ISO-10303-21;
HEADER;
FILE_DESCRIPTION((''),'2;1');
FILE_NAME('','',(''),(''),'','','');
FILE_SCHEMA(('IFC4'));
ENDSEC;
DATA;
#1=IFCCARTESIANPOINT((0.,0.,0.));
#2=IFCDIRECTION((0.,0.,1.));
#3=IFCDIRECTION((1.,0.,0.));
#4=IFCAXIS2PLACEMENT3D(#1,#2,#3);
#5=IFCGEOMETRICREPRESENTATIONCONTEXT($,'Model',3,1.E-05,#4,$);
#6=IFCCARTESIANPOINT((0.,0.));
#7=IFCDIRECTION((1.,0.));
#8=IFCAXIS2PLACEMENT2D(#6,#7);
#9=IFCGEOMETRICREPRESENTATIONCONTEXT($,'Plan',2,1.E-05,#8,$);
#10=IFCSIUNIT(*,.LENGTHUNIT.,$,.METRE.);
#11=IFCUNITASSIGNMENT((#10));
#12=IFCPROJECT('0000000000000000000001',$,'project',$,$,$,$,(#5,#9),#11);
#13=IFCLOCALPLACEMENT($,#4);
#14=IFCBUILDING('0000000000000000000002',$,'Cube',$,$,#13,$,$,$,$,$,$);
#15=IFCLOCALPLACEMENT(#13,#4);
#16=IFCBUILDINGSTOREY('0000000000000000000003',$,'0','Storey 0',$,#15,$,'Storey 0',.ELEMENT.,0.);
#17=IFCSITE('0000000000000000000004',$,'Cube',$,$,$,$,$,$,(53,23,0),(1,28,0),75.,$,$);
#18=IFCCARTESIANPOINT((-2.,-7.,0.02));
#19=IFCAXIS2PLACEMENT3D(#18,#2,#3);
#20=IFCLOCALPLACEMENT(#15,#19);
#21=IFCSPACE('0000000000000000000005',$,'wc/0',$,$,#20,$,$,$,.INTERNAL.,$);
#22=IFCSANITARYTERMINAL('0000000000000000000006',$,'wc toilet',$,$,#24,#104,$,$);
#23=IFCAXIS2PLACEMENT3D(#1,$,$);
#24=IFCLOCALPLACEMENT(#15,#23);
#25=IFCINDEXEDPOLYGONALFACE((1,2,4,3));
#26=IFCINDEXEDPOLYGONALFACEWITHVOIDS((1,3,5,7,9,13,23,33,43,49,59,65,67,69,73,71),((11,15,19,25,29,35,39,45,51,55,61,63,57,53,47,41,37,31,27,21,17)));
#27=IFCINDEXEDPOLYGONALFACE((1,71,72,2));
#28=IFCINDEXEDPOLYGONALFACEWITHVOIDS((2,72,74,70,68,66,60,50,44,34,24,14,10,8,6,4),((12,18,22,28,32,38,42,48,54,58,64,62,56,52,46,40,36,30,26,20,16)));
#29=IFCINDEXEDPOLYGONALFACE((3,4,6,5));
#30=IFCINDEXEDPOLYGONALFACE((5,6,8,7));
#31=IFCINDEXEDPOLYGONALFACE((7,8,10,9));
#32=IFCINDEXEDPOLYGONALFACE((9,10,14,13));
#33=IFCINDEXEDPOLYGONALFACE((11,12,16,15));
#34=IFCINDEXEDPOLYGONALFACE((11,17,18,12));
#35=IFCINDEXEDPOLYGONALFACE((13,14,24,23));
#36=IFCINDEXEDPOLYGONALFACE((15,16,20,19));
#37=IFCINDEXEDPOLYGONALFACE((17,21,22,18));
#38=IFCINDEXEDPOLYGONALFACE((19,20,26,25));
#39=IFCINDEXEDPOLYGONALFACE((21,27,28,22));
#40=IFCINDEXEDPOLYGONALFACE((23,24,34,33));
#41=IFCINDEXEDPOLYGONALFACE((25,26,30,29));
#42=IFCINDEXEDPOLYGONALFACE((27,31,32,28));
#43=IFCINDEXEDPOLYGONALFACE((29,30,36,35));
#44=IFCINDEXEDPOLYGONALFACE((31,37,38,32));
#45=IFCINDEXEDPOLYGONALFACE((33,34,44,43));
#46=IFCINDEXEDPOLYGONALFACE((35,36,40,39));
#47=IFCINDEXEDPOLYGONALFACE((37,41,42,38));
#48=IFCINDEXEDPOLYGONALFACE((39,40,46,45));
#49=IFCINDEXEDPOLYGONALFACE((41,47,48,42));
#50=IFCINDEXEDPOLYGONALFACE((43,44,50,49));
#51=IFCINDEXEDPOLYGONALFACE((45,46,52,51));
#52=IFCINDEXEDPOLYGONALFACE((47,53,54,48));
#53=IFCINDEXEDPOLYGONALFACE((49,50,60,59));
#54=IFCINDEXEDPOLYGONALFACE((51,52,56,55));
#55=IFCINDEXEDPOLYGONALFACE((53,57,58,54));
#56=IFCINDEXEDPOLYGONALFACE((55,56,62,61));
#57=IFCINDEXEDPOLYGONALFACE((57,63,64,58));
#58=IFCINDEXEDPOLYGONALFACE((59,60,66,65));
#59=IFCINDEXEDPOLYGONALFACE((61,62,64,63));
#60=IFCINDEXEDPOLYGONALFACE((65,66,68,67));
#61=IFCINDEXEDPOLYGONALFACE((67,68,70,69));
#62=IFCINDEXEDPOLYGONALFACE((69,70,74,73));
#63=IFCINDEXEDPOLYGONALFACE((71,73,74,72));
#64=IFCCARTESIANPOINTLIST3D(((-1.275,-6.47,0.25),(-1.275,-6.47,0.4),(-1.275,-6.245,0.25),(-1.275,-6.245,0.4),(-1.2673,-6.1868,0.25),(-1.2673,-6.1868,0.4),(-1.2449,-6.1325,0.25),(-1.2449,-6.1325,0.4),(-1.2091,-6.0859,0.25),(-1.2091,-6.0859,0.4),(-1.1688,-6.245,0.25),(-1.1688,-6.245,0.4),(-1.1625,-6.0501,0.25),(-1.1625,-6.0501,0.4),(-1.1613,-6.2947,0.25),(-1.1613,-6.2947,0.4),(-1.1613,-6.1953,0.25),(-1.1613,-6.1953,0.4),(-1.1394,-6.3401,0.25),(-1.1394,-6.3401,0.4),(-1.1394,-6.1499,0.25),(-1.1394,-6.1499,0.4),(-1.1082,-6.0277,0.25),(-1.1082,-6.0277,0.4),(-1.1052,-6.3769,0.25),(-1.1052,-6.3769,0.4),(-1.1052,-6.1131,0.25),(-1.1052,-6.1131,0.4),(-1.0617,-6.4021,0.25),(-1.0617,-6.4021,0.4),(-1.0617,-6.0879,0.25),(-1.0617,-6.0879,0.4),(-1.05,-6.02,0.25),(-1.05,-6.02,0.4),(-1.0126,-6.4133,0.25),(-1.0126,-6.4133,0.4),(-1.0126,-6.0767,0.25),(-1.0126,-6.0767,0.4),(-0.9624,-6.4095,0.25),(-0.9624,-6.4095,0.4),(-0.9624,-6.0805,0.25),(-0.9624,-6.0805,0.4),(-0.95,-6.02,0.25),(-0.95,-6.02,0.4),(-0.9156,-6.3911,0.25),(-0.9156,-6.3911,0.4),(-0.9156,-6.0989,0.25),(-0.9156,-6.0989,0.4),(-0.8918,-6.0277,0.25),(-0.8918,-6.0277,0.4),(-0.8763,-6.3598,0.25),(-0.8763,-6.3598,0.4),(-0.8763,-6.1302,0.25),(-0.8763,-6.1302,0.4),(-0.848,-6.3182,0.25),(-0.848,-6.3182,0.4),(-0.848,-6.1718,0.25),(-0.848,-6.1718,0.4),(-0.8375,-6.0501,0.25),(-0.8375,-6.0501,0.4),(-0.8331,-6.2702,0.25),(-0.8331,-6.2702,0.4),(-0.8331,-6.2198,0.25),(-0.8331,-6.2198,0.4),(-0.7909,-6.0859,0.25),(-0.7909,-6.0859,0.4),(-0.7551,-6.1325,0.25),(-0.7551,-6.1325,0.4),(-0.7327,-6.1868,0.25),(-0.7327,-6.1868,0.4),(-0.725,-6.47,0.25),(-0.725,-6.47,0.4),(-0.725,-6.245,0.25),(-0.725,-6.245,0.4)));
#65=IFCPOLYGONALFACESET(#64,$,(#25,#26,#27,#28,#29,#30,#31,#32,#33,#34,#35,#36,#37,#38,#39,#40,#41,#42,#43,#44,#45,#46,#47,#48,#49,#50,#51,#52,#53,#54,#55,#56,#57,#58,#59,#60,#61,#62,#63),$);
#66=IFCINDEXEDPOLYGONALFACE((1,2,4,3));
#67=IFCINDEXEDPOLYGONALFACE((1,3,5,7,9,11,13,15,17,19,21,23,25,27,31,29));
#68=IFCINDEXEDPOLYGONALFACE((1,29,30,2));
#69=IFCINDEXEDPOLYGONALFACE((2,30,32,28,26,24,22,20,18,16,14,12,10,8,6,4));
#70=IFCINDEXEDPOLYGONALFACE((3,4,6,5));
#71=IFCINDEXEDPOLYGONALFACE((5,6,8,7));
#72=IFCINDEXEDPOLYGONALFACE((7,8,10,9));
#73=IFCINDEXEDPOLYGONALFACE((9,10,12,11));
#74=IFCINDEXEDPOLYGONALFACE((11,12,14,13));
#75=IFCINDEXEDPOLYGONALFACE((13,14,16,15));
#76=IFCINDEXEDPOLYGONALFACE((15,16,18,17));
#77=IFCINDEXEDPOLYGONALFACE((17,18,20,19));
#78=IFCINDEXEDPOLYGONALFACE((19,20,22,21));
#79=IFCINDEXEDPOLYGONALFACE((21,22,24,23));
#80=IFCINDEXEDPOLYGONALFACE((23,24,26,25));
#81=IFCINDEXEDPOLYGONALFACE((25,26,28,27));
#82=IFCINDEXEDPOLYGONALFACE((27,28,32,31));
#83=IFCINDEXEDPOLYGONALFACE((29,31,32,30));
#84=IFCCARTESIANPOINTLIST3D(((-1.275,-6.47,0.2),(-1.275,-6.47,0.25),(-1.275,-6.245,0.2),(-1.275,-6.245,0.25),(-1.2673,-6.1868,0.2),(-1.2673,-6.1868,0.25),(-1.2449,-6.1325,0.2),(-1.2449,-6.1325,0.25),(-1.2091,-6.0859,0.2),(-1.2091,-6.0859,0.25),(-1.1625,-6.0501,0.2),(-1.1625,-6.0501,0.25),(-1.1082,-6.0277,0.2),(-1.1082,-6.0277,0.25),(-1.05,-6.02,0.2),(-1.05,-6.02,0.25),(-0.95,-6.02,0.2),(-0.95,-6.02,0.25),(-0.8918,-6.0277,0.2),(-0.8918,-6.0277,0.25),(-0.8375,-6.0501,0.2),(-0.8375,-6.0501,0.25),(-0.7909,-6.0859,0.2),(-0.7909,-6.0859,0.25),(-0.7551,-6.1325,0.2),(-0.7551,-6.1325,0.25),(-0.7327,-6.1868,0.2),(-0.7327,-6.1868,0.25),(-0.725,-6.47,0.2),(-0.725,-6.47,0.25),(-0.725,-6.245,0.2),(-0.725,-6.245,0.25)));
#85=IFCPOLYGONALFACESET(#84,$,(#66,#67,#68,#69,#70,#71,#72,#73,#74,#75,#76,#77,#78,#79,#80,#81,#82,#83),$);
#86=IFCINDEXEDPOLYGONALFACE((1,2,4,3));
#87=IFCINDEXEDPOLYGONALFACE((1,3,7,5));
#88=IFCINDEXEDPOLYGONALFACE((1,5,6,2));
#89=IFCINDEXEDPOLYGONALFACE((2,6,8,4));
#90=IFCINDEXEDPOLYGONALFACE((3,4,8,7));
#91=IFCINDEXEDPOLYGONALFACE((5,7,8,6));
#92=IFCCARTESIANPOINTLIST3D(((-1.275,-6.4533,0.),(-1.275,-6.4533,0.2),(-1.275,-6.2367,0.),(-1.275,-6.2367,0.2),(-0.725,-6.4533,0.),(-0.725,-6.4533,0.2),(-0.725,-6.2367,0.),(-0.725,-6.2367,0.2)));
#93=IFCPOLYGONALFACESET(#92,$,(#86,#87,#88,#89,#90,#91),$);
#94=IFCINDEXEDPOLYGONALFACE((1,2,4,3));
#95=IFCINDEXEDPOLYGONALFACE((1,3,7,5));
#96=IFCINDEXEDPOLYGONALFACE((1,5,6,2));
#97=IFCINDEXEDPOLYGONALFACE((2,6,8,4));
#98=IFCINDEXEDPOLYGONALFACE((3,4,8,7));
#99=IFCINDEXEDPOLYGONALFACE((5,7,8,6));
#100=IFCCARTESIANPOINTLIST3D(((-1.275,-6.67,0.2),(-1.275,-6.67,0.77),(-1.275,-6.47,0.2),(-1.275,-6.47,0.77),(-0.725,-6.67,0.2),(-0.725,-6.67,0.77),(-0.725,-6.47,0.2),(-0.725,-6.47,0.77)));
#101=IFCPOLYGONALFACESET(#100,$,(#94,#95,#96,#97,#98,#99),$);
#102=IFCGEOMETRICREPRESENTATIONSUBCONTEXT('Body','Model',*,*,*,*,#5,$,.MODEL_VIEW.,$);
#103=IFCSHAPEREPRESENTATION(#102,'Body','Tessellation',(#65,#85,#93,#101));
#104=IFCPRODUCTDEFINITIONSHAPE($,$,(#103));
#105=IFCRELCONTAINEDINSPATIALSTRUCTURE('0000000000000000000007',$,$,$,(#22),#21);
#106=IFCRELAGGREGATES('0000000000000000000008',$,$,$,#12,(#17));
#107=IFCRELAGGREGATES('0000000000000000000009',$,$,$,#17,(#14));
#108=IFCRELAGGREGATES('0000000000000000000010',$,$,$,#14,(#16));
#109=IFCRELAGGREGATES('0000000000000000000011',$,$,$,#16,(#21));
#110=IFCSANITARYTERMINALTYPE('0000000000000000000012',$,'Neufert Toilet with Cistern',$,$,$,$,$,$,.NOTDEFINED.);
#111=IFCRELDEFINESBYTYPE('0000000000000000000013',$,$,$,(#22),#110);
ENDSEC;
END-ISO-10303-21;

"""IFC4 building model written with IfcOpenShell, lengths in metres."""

from ifc_helpers import new_model, entity, si_unit, frame, frame_2d, origin_with_axes, origin_2d_with_axis, place, context, subcontext, project, spatial, line, arc, indexed_curve, circle_curve, outline, extrude, shape, source, transform, mapped, type_object, type_shapes, element, save


model = new_model("IFC4")

# Units and contexts
model_context = context("Model", 3, precision=1e-05, world=origin_with_axes())
plan_context = context("Plan", 2, precision=1e-05, world=origin_2d_with_axis())
body_context_1 = subcontext(model_context, "Body", "Model", "MODEL_VIEW")
body_context_2 = subcontext(plan_context, "Body", "Plan", "PLAN_VIEW")
ifc_project = project(units=[si_unit("LENGTHUNIT", "METRE")], contexts=[model_context, plan_context])

# Site, building, storey
site = spatial("IfcSite", under=ifc_project, Name="Cube", RefLatitude=(53, 23, 0), RefLongitude=(1, 28, 0), RefElevation=75.0)
building_placement = place(None, origin_with_axes())
building = spatial("IfcBuilding", under=site, at=building_placement, Name="Cube")
storey_placement = place(building_placement, origin_with_axes())
storey = spatial("IfcBuildingStorey", under=building, at=storey_placement, Name="0", Description="Storey 0", LongName="Storey 0", CompositionType="ELEMENT", Elevation=0.0)

# Shared definitions
space_1_placement = place(storey_placement, frame((-2.0, -7.0, 0.02), z_axis=(0.0, 0.0, 1.0), x_axis=(1.0, 0.0, 0.0)))
space_1 = spatial("IfcSpace", under=storey, at=space_1_placement, Name="wc/0", PredefinedType="INTERNAL")

# Sanitary terminal
sanitary_terminal_type_1 = type_object("IfcSanitaryTerminalType", Name="Neufert Toilet with Cistern", PredefinedType="NOTDEFINED")
shared_shape_1 = source(origin_with_axes(), body_context_1, "Body", "SweptSolid", [
    extrude(outline(indexed_curve([(-0.275, -0.2), (0.275, -0.2), (0.275, -0.425), (0.2091, -0.5841), (0.05, -0.65), (-0.05, -0.65), (-0.2091, -0.5841), (-0.275, -0.425)], segments=[line(1, 2), line(2, 3), arc(3, 4, 5), line(5, 6), arc(6, 7, 8), line(8, 1)]), holes=[circle_curve(frame_2d((0.0, -0.425)), 0.1688)]), frame((0.0, 0.0, 0.25), z_axis=(0.0, 0.0, 1.0), x_axis=(1.0, 0.0, 0.0)), (0.0, 0.0, 1.0), 0.15),
    extrude(outline(indexed_curve([(-0.275, -0.2), (0.275, -0.2), (0.275, -0.425), (0.2091, -0.5841), (0.05, -0.65), (-0.05, -0.65), (-0.2091, -0.5841), (-0.275, -0.425)], segments=[line(1, 2), line(2, 3), arc(3, 4, 5), line(5, 6), arc(6, 7, 8), line(8, 1)])), frame((0.0, 0.0, 0.2), z_axis=(0.0, 0.0, 1.0), x_axis=(1.0, 0.0, 0.0)), (0.0, 0.0, 1.0), 0.05),
    extrude(outline(indexed_curve([(-0.275, -0.2167), (0.275, -0.2167), (0.275, -0.4333), (-0.275, -0.4333)], segments=[line(1, 2, 3, 4, 1)])), origin_with_axes(), (0.0, 0.0, 1.0), 0.2),
    extrude(outline(indexed_curve([(-0.275, 0.0), (0.275, 0.0), (0.275, -0.2), (-0.275, -0.2)], segments=[line(1, 2, 3, 4, 1)])), frame((0.0, 0.0, 0.2), z_axis=(0.0, 0.0, 1.0), x_axis=(1.0, 0.0, 0.0)), (0.0, 0.0, 1.0), 0.57),
])
shared_shape_2 = source(origin_with_axes(), body_context_2, "Body", "Curve2D", [
    entity("IfcIndexedPolyCurve", entity("IfcCartesianPointList2D", [[-0.275, 0.0], [0.275, 0.0], [0.275, -0.2], [-0.275, -0.2]]), [entity("IfcLineIndex", [1, 2, 3, 4, 1])]),
    entity("IfcIndexedPolyCurve", entity("IfcCartesianPointList2D", [[0.165, -0.2], [0.1925, -0.335]])),
    entity("IfcTrimmedCurve", entity("IfcEllipse", entity("IfcAxis2Placement2D", entity("IfcCartesianPoint", [0.0, -0.335]), entity("IfcDirection", [1.0, 0.0])), 0.1925, 0.315), [entity("IfcCartesianPoint", [-0.1925, -0.335])], [entity("IfcCartesianPoint", [0.1925, -0.335])], True, "CARTESIAN"),
    entity("IfcIndexedPolyCurve", entity("IfcCartesianPointList2D", [[-0.165, -0.2], [-0.1925, -0.335]])),
    entity("IfcEllipse", entity("IfcAxis2Placement2D", entity("IfcCartesianPoint", [0.0, -0.452]), entity("IfcDirection", [1.0, 0.0])), 0.1313, 0.1575),
    entity("IfcIndexedPolyCurve", entity("IfcCartesianPointList2D", [[-0.0344, -0.452], [-0.0344, -0.4295], [0.0344, -0.4295], [0.0344, -0.452]])),
    entity("IfcTrimmedCurve", entity("IfcEllipse", entity("IfcAxis2Placement2D", entity("IfcCartesianPoint", [0.0, -0.452]), entity("IfcDirection", [1.0, 0.0])), 0.0344, 0.0225), [entity("IfcCartesianPoint", [-0.0344, -0.452])], [entity("IfcCartesianPoint", [0.0344, -0.452])], True, "CARTESIAN"),
])
type_shapes(sanitary_terminal_type_1, [shared_shape_1, shared_shape_2])
sanitary_terminal_1_placement = place(space_1_placement, frame((1.0, 0.33, -0.02), z_axis=(0.0, 0.0, 1.0), x_axis=(-1.0, 0.0, 0.0)))
element("IfcSanitaryTerminal", 1, at=sanitary_terminal_1_placement, inside=space_1, type_object=sanitary_terminal_type_1, Name="wc toilet", shapes=[
    shape(body_context_1, "Body", "MappedRepresentation", [mapped(shared_shape_1, transform((0.0, 0.0, 0.0), x_axis=(1.0, 0.0, 0.0), y_axis=(0.0, 1.0, 0.0), z_axis=(0.0, 0.0, 1.0), scale=1.0))]),
    shape(body_context_2, "Body", "MappedRepresentation", [mapped(shared_shape_2, transform((0.0, 0.0, 0.0), x_axis=(1.0, 0.0, 0.0), y_axis=(0.0, 1.0, 0.0), z_axis=(0.0, 0.0, 1.0), scale=1.0))]),
])

save(model, "model.ifc")
